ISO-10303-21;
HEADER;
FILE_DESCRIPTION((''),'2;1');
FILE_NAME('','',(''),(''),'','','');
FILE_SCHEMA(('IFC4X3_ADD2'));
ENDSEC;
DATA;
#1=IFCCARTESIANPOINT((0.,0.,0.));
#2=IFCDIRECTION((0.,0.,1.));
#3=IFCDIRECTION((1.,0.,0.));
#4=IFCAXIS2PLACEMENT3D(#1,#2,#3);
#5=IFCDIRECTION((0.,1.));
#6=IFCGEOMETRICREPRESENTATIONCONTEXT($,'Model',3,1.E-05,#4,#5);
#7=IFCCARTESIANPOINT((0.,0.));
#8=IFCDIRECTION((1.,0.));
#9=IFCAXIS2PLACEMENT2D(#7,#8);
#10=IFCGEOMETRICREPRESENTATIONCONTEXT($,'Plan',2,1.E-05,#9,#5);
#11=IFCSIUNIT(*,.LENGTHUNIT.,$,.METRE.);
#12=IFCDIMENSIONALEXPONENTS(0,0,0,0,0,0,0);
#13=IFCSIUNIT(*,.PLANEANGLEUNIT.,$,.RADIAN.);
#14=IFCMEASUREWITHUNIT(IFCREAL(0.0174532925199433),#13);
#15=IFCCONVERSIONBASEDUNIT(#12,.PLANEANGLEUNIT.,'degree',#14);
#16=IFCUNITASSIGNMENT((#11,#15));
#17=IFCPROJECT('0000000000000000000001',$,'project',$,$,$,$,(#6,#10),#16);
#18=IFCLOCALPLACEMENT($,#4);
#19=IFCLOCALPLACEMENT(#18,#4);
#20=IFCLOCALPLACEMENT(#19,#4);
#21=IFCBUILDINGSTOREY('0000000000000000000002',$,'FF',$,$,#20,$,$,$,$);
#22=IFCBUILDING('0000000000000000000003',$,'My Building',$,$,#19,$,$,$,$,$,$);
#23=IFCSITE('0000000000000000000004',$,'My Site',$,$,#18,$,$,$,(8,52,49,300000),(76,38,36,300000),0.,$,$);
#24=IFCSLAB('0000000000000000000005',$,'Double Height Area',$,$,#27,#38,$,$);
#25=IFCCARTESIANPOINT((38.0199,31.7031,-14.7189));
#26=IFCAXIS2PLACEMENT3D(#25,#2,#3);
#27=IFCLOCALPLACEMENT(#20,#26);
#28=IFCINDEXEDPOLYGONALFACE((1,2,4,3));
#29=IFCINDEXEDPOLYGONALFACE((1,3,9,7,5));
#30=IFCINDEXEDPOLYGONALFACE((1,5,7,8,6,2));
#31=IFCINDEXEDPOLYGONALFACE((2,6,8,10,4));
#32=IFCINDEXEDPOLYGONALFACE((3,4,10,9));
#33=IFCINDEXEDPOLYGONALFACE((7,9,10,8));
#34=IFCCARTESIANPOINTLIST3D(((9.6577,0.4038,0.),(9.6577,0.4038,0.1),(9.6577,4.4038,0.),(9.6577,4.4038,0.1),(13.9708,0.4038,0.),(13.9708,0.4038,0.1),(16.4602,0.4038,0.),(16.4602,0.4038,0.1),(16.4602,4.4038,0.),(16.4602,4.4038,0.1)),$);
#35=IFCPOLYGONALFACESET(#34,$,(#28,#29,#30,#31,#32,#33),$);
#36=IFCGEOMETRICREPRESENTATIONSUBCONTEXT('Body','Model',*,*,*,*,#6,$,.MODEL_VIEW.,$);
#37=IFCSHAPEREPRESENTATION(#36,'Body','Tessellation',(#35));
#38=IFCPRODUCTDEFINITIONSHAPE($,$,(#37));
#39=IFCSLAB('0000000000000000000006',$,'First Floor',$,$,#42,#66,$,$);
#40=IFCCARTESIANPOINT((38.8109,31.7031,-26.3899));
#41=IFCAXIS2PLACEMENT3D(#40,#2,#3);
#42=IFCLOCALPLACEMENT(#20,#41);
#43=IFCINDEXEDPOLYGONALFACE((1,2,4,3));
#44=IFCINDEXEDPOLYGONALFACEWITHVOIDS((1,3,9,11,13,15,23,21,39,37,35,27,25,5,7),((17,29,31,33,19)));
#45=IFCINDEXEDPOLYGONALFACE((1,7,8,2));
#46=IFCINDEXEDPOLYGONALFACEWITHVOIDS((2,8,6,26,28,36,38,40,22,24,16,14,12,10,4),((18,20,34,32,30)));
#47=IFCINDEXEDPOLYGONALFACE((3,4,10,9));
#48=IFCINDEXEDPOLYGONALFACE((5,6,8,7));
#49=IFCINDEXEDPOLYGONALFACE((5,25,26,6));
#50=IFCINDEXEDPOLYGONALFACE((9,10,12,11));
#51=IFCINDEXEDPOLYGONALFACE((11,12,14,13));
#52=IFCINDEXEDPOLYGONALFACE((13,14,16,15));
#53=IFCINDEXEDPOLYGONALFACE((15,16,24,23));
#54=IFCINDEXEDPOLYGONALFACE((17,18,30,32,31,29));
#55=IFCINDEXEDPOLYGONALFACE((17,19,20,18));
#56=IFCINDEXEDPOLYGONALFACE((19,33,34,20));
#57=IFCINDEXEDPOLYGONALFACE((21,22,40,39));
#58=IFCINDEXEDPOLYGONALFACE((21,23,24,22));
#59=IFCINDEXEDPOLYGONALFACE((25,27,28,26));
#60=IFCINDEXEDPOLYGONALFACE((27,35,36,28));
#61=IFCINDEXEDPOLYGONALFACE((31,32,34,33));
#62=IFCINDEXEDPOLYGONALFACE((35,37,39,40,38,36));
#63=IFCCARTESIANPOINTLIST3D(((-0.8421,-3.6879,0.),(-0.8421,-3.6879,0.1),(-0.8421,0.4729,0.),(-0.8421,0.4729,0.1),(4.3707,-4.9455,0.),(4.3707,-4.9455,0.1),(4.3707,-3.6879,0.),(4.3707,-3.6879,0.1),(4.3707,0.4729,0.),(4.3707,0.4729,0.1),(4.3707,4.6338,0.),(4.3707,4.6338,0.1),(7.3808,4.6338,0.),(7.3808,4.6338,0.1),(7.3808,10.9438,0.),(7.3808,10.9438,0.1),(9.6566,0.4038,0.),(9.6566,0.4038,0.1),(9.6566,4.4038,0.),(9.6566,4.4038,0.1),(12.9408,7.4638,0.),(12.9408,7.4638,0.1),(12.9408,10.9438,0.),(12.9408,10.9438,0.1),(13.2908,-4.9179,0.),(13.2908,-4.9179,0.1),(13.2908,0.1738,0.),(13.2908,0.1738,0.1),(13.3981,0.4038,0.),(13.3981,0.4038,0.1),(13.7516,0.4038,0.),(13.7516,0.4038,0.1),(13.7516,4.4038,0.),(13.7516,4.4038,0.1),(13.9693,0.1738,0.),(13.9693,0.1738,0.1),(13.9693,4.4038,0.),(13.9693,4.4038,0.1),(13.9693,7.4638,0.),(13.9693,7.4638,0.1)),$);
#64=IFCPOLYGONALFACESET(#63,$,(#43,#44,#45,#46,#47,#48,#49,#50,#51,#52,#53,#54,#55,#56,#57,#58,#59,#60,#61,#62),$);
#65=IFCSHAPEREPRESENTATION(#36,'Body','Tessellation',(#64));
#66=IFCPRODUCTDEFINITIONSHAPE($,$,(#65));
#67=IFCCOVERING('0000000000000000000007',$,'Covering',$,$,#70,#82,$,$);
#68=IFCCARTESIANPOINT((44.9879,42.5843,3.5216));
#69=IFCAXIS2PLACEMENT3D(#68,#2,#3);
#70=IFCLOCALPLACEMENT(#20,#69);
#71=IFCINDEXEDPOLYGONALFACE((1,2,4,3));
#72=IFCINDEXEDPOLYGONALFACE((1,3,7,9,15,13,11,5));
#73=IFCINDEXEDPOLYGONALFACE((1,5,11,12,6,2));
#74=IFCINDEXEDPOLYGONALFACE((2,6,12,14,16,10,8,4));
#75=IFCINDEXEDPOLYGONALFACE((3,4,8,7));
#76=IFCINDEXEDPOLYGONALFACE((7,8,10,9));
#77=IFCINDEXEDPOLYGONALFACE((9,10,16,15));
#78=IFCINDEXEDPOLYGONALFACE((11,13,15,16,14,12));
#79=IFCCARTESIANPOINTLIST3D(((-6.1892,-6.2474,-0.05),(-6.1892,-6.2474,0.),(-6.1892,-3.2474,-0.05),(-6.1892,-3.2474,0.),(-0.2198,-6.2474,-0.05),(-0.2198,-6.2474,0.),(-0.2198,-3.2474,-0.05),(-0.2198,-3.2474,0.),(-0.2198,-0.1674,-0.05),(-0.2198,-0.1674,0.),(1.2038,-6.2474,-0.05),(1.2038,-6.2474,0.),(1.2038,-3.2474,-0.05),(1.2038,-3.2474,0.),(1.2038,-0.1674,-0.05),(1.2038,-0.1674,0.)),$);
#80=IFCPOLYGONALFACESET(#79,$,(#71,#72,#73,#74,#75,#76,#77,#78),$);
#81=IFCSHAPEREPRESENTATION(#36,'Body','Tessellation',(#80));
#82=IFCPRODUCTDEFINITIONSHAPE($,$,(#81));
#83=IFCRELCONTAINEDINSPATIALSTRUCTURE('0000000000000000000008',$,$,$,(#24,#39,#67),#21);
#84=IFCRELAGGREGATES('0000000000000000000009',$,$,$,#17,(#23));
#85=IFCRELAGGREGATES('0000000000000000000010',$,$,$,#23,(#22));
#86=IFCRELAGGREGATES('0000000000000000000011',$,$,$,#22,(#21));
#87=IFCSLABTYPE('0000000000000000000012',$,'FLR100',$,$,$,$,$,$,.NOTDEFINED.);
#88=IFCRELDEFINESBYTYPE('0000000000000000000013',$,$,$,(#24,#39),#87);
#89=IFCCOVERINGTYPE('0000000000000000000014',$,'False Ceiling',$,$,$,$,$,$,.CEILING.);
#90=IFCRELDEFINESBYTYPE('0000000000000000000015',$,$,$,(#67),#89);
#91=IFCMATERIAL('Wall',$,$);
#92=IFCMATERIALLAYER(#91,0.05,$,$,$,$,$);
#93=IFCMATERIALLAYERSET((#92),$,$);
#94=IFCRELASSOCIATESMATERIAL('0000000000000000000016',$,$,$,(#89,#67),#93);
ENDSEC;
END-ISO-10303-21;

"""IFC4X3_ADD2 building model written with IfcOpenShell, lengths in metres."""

from ifc_helpers import new_model, entity, si_unit, converted_unit, direction, frame, origin_with_axes, origin_2d_with_axis, place, context, subcontext, project, spatial, indexed_curve, outline, extrude, material, layer, layer_set, layer_usage, type_object, element, save


model = new_model("IFC4X3_ADD2")

# Units and contexts
model_context = context("Model", 3, precision=1e-05, world=origin_with_axes(), true_north=direction((0.0, 1.0)))
plan_context = context("Plan", 2, precision=1e-05, world=origin_2d_with_axis(), true_north=direction((0.0, 1.0)))
body_context = subcontext(model_context, "Body", "Model", "MODEL_VIEW")
ifc_project = project(units=[si_unit("LENGTHUNIT", "METRE"), converted_unit("PLANEANGLEUNIT", "degree", entity("IfcReal", 0.0174532925199433), si_unit("PLANEANGLEUNIT", "RADIAN"), dimensions=[0, 0, 0, 0, 0, 0, 0])], contexts=[model_context, plan_context])

# Site, building, storey
site_placement = place(None, origin_with_axes())
site = spatial("IfcSite", under=ifc_project, at=site_placement, Name="My Site", RefLatitude=(8, 52, 49, 300000), RefLongitude=(76, 38, 36, 300000), RefElevation=0.0)
building_placement = place(site_placement, origin_with_axes())
building = spatial("IfcBuilding", under=site, at=building_placement, Name="My Building")
storey_placement = place(building_placement, origin_with_axes())
storey = spatial("IfcBuildingStorey", under=building, at=storey_placement, Name="FF")

# Slabs
slab_type_1 = type_object("IfcSlabType", Name="FLR100", PredefinedType="NOTDEFINED")
slab_1_placement = place(storey_placement, frame((38.0199, 31.7031, -14.7189), z_axis=(0.0, 0.0, 1.0), x_axis=(1.0, 0.0, 0.0)))
element("IfcSlab", 1, at=slab_1_placement, inside=storey, type_object=slab_type_1, Name="Double Height Area", context=body_context, shape_type="SweptSolid", body=[
    extrude(outline(indexed_curve([(9.6577, 0.4038), (9.6577, 4.4038), (16.4602, 4.4038), (16.4602, 0.4038), (13.9708, 0.4038), (9.6577, 0.4038)])), origin_with_axes(), (0.0, 0.0, 1.0), 0.1),
])
slab_2_placement = place(storey_placement, frame((38.8109, 31.7031, -26.3899), z_axis=(0.0, 0.0, 1.0), x_axis=(1.0, 0.0, 0.0)))
element("IfcSlab", 2, at=slab_2_placement, inside=storey, type_object=slab_type_1, Name="First Floor", context=body_context, shape_type="SweptSolid", body=[
    extrude(outline(indexed_curve([(12.9408, 7.4638), (12.9408, 10.9438), (7.3808, 10.9438), (7.3808, 4.6338), (4.3707, 4.6338), (4.3707, 0.4729), (-0.8421, 0.4729), (-0.8421, -3.6879), (4.3707, -3.6879), (4.3707, -4.9455), (13.2908, -4.9179), (13.2908, 0.1738), (13.9693, 0.1738), (13.9693, 4.4038), (13.9693, 7.4638), (12.9408, 7.4638)]), holes=[indexed_curve([(9.6566, 0.4038), (9.6566, 4.4038), (13.7516, 4.4038), (13.7516, 0.4038), (13.3981, 0.4038), (9.6566, 0.4038)])]), origin_with_axes(), (0.0, 0.0, 1.0), 0.1),
])

# Covering
ifc_material_1 = material(Name="Wall")
ifc_layer_1 = layer(ifc_material_1, 0.05)
ifc_layer_set_1 = layer_set([ifc_layer_1])
ifc_layer_usage_1 = layer_usage(ifc_layer_set_1, "AXIS3", "POSITIVE", -0.05)
covering_type = type_object("IfcCoveringType", Name="False Ceiling", PredefinedType="CEILING", material=ifc_layer_set_1)
covering_placement = place(storey_placement, frame((44.9879, 42.5843, 3.5216), z_axis=(0.0, 0.0, 1.0), x_axis=(1.0, 0.0, 0.0)))
element("IfcCovering", 3, at=covering_placement, inside=storey, type_object=covering_type, material=ifc_layer_usage_1, Name="Covering", context=body_context, shape_type="SweptSolid", body=[
    extrude(outline(indexed_curve([(1.2038, -3.2474), (1.2038, -6.2474), (-0.2198, -6.2474), (-6.1892, -6.2474), (-6.1892, -3.2474), (-0.2198, -3.2474), (-0.2198, -0.1674), (1.2038, -0.1674), (1.2038, -3.2474)])), frame((0.0, 0.0, -0.05), z_axis=(0.0, 0.0, 1.0), x_axis=(1.0, 0.0, 0.0)), (0.0, 0.0, 1.0), 0.05),
])

save(model, "model.ifc")
